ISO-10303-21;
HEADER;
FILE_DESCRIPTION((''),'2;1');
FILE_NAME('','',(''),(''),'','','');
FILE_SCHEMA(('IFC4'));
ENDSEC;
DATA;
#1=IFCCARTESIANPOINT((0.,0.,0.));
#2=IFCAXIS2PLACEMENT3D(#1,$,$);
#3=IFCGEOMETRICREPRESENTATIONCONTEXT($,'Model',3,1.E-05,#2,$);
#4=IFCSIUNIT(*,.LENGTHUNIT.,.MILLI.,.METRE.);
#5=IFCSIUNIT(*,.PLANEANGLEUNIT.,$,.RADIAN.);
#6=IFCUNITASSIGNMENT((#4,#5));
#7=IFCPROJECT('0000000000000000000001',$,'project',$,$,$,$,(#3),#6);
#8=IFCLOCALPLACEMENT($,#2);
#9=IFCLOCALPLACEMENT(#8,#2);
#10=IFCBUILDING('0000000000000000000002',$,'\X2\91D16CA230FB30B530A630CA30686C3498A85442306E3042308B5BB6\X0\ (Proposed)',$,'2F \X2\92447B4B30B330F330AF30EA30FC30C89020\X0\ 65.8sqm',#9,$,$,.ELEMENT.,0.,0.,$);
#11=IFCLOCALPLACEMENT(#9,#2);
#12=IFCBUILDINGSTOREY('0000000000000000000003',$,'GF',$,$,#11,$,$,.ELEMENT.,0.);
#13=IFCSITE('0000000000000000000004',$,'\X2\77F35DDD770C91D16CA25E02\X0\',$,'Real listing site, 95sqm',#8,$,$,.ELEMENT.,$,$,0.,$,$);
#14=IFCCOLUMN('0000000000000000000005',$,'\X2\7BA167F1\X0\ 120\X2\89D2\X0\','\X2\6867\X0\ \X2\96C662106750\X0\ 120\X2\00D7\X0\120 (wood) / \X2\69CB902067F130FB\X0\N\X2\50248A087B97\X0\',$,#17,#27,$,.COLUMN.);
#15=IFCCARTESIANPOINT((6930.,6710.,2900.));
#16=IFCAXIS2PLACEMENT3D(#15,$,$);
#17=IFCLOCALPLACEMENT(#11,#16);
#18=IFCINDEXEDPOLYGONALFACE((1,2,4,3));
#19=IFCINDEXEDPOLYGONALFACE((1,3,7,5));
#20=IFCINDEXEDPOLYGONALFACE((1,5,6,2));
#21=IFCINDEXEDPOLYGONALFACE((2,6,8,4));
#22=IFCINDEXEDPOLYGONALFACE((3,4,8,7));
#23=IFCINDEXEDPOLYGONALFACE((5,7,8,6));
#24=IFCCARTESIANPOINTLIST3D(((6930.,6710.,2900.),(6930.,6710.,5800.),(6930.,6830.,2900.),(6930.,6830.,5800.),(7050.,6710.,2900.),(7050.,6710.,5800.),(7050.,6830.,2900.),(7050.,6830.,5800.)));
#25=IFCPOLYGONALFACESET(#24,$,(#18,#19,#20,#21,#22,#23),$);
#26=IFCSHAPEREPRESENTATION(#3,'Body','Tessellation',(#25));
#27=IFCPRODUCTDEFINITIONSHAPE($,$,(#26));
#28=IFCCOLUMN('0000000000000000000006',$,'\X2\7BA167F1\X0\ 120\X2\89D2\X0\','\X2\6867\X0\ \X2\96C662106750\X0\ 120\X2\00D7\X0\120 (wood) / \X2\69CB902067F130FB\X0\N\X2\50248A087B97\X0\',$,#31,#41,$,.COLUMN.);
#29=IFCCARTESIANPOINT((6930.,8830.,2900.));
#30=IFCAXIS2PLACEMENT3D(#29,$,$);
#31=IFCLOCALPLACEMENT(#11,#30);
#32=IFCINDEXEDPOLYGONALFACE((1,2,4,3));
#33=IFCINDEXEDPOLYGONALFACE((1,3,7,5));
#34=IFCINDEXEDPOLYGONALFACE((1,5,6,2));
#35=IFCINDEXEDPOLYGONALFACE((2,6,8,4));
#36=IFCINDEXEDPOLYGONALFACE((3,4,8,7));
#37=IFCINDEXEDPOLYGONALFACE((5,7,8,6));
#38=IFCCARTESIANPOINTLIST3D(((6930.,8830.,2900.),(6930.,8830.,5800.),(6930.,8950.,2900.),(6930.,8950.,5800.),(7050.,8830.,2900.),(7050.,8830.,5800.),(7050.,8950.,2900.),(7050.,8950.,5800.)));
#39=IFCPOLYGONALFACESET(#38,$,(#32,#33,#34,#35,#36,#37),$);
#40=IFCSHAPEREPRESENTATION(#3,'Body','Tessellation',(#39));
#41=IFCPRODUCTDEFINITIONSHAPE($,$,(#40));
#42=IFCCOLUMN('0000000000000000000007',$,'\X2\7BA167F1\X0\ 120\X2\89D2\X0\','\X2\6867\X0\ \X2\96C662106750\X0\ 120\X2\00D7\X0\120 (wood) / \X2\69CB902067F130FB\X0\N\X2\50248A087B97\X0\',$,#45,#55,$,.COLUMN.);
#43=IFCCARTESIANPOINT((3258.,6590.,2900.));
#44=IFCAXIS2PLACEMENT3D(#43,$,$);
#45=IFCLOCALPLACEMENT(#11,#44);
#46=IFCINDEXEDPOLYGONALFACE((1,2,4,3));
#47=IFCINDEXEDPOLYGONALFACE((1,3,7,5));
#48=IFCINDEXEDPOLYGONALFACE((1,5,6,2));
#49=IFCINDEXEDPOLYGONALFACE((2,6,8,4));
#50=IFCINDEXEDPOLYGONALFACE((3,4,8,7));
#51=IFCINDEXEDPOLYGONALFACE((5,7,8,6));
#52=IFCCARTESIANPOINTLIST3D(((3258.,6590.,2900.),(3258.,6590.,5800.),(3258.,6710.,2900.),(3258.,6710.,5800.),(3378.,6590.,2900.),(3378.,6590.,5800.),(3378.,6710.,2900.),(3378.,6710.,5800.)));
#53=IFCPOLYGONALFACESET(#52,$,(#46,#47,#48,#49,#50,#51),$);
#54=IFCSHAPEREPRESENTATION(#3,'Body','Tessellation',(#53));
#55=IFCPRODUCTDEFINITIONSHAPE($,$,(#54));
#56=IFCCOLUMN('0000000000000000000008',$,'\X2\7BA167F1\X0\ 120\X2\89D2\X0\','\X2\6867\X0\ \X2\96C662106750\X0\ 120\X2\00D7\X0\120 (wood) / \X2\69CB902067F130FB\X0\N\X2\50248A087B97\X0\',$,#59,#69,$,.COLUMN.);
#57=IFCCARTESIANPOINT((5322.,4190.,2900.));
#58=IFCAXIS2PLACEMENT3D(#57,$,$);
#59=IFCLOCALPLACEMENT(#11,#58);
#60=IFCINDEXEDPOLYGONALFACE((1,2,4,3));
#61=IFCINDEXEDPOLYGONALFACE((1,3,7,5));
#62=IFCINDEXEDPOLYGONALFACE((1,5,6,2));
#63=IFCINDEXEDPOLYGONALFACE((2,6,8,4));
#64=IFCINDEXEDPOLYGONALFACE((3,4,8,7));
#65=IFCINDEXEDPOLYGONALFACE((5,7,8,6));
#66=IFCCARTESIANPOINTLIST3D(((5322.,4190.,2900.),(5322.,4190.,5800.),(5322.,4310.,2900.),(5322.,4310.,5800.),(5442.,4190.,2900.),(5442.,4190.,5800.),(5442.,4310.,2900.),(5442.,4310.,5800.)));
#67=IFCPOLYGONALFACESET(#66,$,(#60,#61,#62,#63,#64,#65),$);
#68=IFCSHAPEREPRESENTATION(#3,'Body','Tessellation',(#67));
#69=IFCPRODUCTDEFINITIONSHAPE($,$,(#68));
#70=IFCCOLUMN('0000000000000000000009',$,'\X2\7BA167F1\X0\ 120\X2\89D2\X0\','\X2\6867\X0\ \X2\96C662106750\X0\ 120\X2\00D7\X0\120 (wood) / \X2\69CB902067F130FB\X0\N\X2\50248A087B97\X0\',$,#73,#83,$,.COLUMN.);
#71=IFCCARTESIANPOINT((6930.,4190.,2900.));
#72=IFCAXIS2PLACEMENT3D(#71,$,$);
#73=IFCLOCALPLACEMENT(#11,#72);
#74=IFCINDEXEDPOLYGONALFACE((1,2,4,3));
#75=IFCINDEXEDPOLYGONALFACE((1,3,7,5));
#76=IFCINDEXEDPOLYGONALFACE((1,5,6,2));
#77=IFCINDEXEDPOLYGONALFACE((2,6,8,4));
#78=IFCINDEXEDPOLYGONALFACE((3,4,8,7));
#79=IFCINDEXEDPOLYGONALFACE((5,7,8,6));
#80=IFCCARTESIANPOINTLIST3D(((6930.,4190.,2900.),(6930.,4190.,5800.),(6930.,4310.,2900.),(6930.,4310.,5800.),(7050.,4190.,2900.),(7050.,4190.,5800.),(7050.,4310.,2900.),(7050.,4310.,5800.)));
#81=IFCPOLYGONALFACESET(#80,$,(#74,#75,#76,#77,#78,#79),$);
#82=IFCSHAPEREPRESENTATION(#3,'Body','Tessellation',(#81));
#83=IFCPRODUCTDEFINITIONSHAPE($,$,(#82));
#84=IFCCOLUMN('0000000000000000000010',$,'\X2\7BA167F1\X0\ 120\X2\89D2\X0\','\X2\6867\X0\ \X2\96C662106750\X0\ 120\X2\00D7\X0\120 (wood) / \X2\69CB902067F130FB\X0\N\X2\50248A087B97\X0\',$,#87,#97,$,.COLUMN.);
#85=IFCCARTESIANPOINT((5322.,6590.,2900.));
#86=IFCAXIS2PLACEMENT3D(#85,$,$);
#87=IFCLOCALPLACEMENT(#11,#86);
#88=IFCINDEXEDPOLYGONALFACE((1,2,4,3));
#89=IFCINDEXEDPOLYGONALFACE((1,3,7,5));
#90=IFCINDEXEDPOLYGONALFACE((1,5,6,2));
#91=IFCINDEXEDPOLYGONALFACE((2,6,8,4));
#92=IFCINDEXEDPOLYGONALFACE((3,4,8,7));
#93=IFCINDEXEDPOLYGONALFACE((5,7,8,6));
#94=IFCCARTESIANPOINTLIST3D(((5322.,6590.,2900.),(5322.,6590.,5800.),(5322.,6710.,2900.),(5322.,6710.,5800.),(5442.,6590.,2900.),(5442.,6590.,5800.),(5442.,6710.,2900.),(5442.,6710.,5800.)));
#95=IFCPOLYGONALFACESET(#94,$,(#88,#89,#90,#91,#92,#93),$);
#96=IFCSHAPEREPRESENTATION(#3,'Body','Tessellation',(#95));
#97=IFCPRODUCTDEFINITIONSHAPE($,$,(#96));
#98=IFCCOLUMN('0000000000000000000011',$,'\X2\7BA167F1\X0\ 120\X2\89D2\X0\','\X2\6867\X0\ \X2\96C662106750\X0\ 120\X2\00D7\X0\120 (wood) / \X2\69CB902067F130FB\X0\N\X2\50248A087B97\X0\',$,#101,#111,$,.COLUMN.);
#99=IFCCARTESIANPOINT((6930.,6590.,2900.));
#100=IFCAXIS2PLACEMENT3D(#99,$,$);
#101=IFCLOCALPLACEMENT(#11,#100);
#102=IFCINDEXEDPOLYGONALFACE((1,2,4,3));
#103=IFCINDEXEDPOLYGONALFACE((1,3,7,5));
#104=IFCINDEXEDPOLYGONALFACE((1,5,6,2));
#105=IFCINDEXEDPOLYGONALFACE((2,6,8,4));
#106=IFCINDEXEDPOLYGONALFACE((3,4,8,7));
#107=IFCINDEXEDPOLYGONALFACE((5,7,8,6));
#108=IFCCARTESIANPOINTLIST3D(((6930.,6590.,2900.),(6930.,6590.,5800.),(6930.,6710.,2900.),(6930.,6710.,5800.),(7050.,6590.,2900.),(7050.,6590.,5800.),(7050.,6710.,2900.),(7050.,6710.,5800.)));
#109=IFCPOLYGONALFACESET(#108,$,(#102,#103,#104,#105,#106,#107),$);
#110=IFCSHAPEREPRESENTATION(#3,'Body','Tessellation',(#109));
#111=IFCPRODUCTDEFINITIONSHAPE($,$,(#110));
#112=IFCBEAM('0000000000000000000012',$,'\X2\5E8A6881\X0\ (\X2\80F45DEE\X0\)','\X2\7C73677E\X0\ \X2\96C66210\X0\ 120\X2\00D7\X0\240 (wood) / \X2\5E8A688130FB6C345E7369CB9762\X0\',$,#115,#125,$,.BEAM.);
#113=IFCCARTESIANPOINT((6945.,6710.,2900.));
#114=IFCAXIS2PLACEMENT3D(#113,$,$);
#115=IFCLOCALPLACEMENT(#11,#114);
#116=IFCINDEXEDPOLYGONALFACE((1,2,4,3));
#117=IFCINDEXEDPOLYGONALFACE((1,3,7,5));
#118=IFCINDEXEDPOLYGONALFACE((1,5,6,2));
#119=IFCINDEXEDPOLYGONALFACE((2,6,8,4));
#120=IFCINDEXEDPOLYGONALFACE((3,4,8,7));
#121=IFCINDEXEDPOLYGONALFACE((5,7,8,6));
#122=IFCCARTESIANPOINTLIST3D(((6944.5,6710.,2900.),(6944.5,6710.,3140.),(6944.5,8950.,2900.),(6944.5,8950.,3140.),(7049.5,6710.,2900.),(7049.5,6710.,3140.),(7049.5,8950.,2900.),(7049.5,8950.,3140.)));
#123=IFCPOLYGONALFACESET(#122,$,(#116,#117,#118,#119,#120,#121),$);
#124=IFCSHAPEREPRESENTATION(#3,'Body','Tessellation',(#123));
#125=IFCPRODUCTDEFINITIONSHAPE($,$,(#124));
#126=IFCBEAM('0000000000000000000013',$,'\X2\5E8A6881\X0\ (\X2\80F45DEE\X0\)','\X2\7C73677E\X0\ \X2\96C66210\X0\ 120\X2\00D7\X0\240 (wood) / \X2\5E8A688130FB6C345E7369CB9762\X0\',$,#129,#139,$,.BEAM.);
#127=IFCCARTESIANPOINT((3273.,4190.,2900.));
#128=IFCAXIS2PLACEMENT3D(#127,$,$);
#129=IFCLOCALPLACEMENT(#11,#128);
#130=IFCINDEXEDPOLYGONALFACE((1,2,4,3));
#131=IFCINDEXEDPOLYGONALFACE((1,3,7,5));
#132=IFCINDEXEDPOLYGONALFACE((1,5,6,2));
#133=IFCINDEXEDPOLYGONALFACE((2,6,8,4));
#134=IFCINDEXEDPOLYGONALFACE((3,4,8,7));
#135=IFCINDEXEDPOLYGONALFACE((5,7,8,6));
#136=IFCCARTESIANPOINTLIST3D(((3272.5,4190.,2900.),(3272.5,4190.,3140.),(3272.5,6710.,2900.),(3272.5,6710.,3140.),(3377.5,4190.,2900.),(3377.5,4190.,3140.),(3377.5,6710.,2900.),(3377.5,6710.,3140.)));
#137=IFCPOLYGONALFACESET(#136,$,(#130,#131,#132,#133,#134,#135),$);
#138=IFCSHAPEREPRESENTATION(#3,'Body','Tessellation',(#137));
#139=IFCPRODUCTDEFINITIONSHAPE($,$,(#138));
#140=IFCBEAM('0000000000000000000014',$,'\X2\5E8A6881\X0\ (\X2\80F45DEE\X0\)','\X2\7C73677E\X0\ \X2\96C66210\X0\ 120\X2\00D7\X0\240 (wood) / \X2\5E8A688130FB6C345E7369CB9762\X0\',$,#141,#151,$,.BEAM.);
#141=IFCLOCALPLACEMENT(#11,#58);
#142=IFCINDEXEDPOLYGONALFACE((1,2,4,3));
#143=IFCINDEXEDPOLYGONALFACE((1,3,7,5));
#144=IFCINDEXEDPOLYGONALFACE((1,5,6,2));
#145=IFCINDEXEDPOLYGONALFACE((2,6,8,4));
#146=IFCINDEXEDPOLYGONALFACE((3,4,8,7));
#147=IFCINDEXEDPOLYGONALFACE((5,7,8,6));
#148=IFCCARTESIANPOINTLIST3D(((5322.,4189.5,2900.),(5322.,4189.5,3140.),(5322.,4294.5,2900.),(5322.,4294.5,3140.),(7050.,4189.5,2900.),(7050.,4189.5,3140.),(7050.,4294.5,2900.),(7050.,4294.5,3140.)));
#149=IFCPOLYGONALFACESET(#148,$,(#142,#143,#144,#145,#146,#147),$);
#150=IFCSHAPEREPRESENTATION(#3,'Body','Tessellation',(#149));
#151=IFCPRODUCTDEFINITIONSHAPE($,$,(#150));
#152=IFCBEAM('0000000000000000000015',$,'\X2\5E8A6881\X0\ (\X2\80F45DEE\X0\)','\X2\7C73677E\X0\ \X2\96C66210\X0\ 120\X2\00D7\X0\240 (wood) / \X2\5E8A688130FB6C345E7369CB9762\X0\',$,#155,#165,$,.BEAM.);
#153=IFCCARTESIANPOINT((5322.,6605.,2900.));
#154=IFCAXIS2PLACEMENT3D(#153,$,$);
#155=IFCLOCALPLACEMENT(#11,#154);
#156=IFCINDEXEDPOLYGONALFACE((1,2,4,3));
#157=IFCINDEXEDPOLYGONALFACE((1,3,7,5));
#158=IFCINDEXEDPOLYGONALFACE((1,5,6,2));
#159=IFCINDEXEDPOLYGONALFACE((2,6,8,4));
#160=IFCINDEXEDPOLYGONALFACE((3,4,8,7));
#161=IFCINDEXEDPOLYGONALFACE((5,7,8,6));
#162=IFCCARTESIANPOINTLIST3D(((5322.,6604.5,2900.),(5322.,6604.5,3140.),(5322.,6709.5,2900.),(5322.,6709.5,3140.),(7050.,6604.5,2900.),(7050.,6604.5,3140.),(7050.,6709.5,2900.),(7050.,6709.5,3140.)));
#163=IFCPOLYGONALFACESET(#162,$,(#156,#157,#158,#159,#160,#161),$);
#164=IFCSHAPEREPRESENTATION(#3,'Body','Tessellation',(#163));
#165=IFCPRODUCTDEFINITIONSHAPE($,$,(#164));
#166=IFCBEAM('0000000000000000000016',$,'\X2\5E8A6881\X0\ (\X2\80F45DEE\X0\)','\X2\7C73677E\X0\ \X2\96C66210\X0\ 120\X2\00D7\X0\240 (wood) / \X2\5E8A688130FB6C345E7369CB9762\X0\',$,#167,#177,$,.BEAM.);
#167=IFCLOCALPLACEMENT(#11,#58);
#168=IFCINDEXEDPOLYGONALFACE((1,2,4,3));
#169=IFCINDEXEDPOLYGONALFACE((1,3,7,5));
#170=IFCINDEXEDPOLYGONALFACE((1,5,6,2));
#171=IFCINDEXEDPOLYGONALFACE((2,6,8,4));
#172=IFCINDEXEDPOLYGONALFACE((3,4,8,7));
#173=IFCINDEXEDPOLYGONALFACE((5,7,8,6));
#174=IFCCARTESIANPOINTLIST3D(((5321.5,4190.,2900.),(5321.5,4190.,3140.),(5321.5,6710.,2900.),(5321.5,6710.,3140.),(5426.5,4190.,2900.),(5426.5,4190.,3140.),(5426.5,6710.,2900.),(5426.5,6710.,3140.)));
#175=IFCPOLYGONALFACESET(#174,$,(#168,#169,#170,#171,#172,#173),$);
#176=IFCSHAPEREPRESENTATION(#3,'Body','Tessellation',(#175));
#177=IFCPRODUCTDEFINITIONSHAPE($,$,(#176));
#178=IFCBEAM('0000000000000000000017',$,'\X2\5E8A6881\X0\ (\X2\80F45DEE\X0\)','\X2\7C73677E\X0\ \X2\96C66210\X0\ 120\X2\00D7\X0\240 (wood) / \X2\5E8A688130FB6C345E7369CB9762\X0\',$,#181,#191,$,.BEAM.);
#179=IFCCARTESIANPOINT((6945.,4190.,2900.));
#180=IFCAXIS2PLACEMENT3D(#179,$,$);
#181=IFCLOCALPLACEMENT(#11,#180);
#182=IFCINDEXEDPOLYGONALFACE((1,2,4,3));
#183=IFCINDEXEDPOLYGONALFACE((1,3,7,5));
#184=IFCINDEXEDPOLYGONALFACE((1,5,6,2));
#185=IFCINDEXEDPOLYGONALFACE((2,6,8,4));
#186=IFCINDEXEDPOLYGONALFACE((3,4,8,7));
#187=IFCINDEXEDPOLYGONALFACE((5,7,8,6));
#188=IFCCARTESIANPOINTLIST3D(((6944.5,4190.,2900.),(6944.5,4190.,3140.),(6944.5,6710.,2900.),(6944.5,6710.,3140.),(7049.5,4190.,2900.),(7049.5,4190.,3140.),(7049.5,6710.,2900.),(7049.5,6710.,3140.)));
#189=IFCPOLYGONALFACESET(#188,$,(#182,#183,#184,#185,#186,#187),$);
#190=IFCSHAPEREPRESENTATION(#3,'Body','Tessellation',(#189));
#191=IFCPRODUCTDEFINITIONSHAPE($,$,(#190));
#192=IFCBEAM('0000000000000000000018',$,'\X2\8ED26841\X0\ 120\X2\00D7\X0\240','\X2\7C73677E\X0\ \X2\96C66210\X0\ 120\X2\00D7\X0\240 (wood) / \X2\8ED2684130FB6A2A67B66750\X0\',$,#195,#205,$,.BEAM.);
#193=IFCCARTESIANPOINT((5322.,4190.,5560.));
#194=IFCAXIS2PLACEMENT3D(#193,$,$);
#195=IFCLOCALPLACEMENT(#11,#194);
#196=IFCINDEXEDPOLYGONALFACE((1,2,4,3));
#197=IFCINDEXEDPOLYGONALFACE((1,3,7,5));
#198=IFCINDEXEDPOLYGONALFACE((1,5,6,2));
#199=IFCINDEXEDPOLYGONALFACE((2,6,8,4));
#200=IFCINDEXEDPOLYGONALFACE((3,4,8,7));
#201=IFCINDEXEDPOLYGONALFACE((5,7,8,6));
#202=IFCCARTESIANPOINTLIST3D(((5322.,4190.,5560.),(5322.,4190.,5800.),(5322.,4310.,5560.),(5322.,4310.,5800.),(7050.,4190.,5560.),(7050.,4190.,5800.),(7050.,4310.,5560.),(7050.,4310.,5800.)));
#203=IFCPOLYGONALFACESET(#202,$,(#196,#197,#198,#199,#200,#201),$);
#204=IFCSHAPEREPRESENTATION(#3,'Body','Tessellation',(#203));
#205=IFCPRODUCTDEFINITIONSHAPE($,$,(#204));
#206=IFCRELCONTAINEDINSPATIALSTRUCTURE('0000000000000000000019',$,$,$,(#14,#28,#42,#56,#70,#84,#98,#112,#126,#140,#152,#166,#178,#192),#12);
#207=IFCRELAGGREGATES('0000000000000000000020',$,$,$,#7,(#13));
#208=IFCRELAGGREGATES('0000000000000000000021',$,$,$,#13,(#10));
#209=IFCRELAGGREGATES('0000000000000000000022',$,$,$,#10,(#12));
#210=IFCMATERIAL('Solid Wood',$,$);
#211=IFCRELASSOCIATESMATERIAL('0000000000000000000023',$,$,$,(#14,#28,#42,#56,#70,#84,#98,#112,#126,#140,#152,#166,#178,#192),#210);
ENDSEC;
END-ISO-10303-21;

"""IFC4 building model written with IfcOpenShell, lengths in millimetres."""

from ifc_helpers import new_model, si_unit, frame, frame_2d, origin, place, context, project, spatial, rectangle, extrude, material, element, save


model = new_model("IFC4")

# Units and contexts
model_context = context("Model", 3, precision=1e-05, world=origin())
ifc_project = project(units=[si_unit("LENGTHUNIT", "METRE", prefix="MILLI"), si_unit("PLANEANGLEUNIT", "RADIAN")], contexts=[model_context])

# Site, building, storey
site_placement = place(None, origin())
site = spatial("IfcSite", under=ifc_project, at=site_placement, Name="石川県金沢市", ObjectType="Real listing site, 95sqm", CompositionType="ELEMENT", RefElevation=0.0)
building_placement = place(site_placement, origin())
building = spatial("IfcBuilding", under=site, at=building_placement, Name="金沢・サウナと水風呂のある家 (Proposed)", ObjectType="2F 鉄筋コンクリート造 65.8sqm", CompositionType="ELEMENT", ElevationOfRefHeight=0.0, ElevationOfTerrain=0.0)
storey_placement = place(building_placement, origin())
storey = spatial("IfcBuildingStorey", under=building, at=storey_placement, Name="GF", CompositionType="ELEMENT", Elevation=0.0)

# Columns
ifc_material_1 = material(Name="Solid Wood")
column_1_placement = place(storey_placement, frame((6930.0, 6710.0, 2900.0)))
element("IfcColumn", 1, at=column_1_placement, inside=storey, material=ifc_material_1, Name="管柱 120角", Description="桧 集成材 120×120 (wood) / 構造柱・N値計算", PredefinedType="COLUMN", context=model_context, shape_type="SweptSolid", body=[
    extrude(rectangle(XDim=120.0, YDim=120.0, at=frame_2d((60.0, 60.0))), frame((6930.0, 6710.0, 2900.0)), (0.0, 0.0, 1.0), 2900.0),
])
column_2_placement = place(storey_placement, frame((6930.0, 8830.0, 2900.0)))
element("IfcColumn", 2, at=column_2_placement, inside=storey, material=ifc_material_1, Name="管柱 120角", Description="桧 集成材 120×120 (wood) / 構造柱・N値計算", PredefinedType="COLUMN", context=model_context, shape_type="SweptSolid", body=[
    extrude(rectangle(XDim=120.0, YDim=120.0, at=frame_2d((60.0, 60.0))), frame((6930.0, 8830.0, 2900.0)), (0.0, 0.0, 1.0), 2900.0),
])
column_3_placement = place(storey_placement, frame((3258.0, 6590.0, 2900.0)))
element("IfcColumn", 3, at=column_3_placement, inside=storey, material=ifc_material_1, Name="管柱 120角", Description="桧 集成材 120×120 (wood) / 構造柱・N値計算", PredefinedType="COLUMN", context=model_context, shape_type="SweptSolid", body=[
    extrude(rectangle(XDim=120.0, YDim=120.0, at=frame_2d((60.0, 60.0))), frame((3258.0, 6590.0, 2900.0)), (0.0, 0.0, 1.0), 2900.0),
])
column_4_placement = place(storey_placement, frame((5322.0, 4190.0, 2900.0)))
element("IfcColumn", 4, at=column_4_placement, inside=storey, material=ifc_material_1, Name="管柱 120角", Description="桧 集成材 120×120 (wood) / 構造柱・N値計算", PredefinedType="COLUMN", context=model_context, shape_type="SweptSolid", body=[
    extrude(rectangle(XDim=120.0, YDim=120.0, at=frame_2d((60.0, 60.0))), frame((5322.0, 4190.0, 2900.0)), (0.0, 0.0, 1.0), 2900.0),
])
column_5_placement = place(storey_placement, frame((6930.0, 4190.0, 2900.0)))
element("IfcColumn", 5, at=column_5_placement, inside=storey, material=ifc_material_1, Name="管柱 120角", Description="桧 集成材 120×120 (wood) / 構造柱・N値計算", PredefinedType="COLUMN", context=model_context, shape_type="SweptSolid", body=[
    extrude(rectangle(XDim=120.0, YDim=120.0, at=frame_2d((60.0, 60.0))), frame((6930.0, 4190.0, 2900.0)), (0.0, 0.0, 1.0), 2900.0),
])
column_6_placement = place(storey_placement, frame((5322.0, 6590.0, 2900.0)))
element("IfcColumn", 6, at=column_6_placement, inside=storey, material=ifc_material_1, Name="管柱 120角", Description="桧 集成材 120×120 (wood) / 構造柱・N値計算", PredefinedType="COLUMN", context=model_context, shape_type="SweptSolid", body=[
    extrude(rectangle(XDim=120.0, YDim=120.0, at=frame_2d((60.0, 60.0))), frame((5322.0, 6590.0, 2900.0)), (0.0, 0.0, 1.0), 2900.0),
])
column_7_placement = place(storey_placement, frame((6930.0, 6590.0, 2900.0)))
element("IfcColumn", 7, at=column_7_placement, inside=storey, material=ifc_material_1, Name="管柱 120角", Description="桧 集成材 120×120 (wood) / 構造柱・N値計算", PredefinedType="COLUMN", context=model_context, shape_type="SweptSolid", body=[
    extrude(rectangle(XDim=120.0, YDim=120.0, at=frame_2d((60.0, 60.0))), frame((6930.0, 6590.0, 2900.0)), (0.0, 0.0, 1.0), 2900.0),
])

# Beams
beam_1_placement = place(storey_placement, frame((6945.0, 6710.0, 2900.0)))
element("IfcBeam", 8, at=beam_1_placement, inside=storey, material=ifc_material_1, Name="床梁 (胴差)", Description="米松 集成 120×240 (wood) / 床梁・水平構面", PredefinedType="BEAM", context=model_context, shape_type="SweptSolid", body=[
    extrude(rectangle(XDim=105.0, YDim=2240.0, at=frame_2d((52.0, 1120.0))), frame((6945.0, 6710.0, 2900.0)), (0.0, 0.0, 1.0), 240.0),
])
beam_2_placement = place(storey_placement, frame((3273.0, 4190.0, 2900.0)))
element("IfcBeam", 9, at=beam_2_placement, inside=storey, material=ifc_material_1, Name="床梁 (胴差)", Description="米松 集成 120×240 (wood) / 床梁・水平構面", PredefinedType="BEAM", context=model_context, shape_type="SweptSolid", body=[
    extrude(rectangle(XDim=105.0, YDim=2520.0, at=frame_2d((52.0, 1260.0))), frame((3273.0, 4190.0, 2900.0)), (0.0, 0.0, 1.0), 240.0),
])
beam_3_placement = place(storey_placement, frame((5322.0, 4190.0, 2900.0)))
element("IfcBeam", 10, at=beam_3_placement, inside=storey, material=ifc_material_1, Name="床梁 (胴差)", Description="米松 集成 120×240 (wood) / 床梁・水平構面", PredefinedType="BEAM", context=model_context, shape_type="SweptSolid", body=[
    extrude(rectangle(XDim=1728.0, YDim=105.0, at=frame_2d((864.0, 52.0))), frame((5322.0, 4190.0, 2900.0)), (0.0, 0.0, 1.0), 240.0),
])
beam_4_placement = place(storey_placement, frame((5322.0, 6605.0, 2900.0)))
element("IfcBeam", 11, at=beam_4_placement, inside=storey, material=ifc_material_1, Name="床梁 (胴差)", Description="米松 集成 120×240 (wood) / 床梁・水平構面", PredefinedType="BEAM", context=model_context, shape_type="SweptSolid", body=[
    extrude(rectangle(XDim=1728.0, YDim=105.0, at=frame_2d((864.0, 52.0))), frame((5322.0, 6605.0, 2900.0)), (0.0, 0.0, 1.0), 240.0),
])
beam_5_placement = place(storey_placement, frame((5322.0, 4190.0, 2900.0)))
element("IfcBeam", 12, at=beam_5_placement, inside=storey, material=ifc_material_1, Name="床梁 (胴差)", Description="米松 集成 120×240 (wood) / 床梁・水平構面", PredefinedType="BEAM", context=model_context, shape_type="SweptSolid", body=[
    extrude(rectangle(XDim=105.0, YDim=2520.0, at=frame_2d((52.0, 1260.0))), frame((5322.0, 4190.0, 2900.0)), (0.0, 0.0, 1.0), 240.0),
])
beam_6_placement = place(storey_placement, frame((6945.0, 4190.0, 2900.0)))
element("IfcBeam", 13, at=beam_6_placement, inside=storey, material=ifc_material_1, Name="床梁 (胴差)", Description="米松 集成 120×240 (wood) / 床梁・水平構面", PredefinedType="BEAM", context=model_context, shape_type="SweptSolid", body=[
    extrude(rectangle(XDim=105.0, YDim=2520.0, at=frame_2d((52.0, 1260.0))), frame((6945.0, 4190.0, 2900.0)), (0.0, 0.0, 1.0), 240.0),
])
beam_7_placement = place(storey_placement, frame((5322.0, 4190.0, 5560.0)))
element("IfcBeam", 14, at=beam_7_placement, inside=storey, material=ifc_material_1, Name="軒桁 120×240", Description="米松 集成 120×240 (wood) / 軒桁・横架材", PredefinedType="BEAM", context=model_context, shape_type="SweptSolid", body=[
    extrude(rectangle(XDim=1728.0, YDim=120.0, at=frame_2d((864.0, 60.0))), frame((5322.0, 4190.0, 5560.0)), (0.0, 0.0, 1.0), 240.0),
])

save(model, "model.ifc")
